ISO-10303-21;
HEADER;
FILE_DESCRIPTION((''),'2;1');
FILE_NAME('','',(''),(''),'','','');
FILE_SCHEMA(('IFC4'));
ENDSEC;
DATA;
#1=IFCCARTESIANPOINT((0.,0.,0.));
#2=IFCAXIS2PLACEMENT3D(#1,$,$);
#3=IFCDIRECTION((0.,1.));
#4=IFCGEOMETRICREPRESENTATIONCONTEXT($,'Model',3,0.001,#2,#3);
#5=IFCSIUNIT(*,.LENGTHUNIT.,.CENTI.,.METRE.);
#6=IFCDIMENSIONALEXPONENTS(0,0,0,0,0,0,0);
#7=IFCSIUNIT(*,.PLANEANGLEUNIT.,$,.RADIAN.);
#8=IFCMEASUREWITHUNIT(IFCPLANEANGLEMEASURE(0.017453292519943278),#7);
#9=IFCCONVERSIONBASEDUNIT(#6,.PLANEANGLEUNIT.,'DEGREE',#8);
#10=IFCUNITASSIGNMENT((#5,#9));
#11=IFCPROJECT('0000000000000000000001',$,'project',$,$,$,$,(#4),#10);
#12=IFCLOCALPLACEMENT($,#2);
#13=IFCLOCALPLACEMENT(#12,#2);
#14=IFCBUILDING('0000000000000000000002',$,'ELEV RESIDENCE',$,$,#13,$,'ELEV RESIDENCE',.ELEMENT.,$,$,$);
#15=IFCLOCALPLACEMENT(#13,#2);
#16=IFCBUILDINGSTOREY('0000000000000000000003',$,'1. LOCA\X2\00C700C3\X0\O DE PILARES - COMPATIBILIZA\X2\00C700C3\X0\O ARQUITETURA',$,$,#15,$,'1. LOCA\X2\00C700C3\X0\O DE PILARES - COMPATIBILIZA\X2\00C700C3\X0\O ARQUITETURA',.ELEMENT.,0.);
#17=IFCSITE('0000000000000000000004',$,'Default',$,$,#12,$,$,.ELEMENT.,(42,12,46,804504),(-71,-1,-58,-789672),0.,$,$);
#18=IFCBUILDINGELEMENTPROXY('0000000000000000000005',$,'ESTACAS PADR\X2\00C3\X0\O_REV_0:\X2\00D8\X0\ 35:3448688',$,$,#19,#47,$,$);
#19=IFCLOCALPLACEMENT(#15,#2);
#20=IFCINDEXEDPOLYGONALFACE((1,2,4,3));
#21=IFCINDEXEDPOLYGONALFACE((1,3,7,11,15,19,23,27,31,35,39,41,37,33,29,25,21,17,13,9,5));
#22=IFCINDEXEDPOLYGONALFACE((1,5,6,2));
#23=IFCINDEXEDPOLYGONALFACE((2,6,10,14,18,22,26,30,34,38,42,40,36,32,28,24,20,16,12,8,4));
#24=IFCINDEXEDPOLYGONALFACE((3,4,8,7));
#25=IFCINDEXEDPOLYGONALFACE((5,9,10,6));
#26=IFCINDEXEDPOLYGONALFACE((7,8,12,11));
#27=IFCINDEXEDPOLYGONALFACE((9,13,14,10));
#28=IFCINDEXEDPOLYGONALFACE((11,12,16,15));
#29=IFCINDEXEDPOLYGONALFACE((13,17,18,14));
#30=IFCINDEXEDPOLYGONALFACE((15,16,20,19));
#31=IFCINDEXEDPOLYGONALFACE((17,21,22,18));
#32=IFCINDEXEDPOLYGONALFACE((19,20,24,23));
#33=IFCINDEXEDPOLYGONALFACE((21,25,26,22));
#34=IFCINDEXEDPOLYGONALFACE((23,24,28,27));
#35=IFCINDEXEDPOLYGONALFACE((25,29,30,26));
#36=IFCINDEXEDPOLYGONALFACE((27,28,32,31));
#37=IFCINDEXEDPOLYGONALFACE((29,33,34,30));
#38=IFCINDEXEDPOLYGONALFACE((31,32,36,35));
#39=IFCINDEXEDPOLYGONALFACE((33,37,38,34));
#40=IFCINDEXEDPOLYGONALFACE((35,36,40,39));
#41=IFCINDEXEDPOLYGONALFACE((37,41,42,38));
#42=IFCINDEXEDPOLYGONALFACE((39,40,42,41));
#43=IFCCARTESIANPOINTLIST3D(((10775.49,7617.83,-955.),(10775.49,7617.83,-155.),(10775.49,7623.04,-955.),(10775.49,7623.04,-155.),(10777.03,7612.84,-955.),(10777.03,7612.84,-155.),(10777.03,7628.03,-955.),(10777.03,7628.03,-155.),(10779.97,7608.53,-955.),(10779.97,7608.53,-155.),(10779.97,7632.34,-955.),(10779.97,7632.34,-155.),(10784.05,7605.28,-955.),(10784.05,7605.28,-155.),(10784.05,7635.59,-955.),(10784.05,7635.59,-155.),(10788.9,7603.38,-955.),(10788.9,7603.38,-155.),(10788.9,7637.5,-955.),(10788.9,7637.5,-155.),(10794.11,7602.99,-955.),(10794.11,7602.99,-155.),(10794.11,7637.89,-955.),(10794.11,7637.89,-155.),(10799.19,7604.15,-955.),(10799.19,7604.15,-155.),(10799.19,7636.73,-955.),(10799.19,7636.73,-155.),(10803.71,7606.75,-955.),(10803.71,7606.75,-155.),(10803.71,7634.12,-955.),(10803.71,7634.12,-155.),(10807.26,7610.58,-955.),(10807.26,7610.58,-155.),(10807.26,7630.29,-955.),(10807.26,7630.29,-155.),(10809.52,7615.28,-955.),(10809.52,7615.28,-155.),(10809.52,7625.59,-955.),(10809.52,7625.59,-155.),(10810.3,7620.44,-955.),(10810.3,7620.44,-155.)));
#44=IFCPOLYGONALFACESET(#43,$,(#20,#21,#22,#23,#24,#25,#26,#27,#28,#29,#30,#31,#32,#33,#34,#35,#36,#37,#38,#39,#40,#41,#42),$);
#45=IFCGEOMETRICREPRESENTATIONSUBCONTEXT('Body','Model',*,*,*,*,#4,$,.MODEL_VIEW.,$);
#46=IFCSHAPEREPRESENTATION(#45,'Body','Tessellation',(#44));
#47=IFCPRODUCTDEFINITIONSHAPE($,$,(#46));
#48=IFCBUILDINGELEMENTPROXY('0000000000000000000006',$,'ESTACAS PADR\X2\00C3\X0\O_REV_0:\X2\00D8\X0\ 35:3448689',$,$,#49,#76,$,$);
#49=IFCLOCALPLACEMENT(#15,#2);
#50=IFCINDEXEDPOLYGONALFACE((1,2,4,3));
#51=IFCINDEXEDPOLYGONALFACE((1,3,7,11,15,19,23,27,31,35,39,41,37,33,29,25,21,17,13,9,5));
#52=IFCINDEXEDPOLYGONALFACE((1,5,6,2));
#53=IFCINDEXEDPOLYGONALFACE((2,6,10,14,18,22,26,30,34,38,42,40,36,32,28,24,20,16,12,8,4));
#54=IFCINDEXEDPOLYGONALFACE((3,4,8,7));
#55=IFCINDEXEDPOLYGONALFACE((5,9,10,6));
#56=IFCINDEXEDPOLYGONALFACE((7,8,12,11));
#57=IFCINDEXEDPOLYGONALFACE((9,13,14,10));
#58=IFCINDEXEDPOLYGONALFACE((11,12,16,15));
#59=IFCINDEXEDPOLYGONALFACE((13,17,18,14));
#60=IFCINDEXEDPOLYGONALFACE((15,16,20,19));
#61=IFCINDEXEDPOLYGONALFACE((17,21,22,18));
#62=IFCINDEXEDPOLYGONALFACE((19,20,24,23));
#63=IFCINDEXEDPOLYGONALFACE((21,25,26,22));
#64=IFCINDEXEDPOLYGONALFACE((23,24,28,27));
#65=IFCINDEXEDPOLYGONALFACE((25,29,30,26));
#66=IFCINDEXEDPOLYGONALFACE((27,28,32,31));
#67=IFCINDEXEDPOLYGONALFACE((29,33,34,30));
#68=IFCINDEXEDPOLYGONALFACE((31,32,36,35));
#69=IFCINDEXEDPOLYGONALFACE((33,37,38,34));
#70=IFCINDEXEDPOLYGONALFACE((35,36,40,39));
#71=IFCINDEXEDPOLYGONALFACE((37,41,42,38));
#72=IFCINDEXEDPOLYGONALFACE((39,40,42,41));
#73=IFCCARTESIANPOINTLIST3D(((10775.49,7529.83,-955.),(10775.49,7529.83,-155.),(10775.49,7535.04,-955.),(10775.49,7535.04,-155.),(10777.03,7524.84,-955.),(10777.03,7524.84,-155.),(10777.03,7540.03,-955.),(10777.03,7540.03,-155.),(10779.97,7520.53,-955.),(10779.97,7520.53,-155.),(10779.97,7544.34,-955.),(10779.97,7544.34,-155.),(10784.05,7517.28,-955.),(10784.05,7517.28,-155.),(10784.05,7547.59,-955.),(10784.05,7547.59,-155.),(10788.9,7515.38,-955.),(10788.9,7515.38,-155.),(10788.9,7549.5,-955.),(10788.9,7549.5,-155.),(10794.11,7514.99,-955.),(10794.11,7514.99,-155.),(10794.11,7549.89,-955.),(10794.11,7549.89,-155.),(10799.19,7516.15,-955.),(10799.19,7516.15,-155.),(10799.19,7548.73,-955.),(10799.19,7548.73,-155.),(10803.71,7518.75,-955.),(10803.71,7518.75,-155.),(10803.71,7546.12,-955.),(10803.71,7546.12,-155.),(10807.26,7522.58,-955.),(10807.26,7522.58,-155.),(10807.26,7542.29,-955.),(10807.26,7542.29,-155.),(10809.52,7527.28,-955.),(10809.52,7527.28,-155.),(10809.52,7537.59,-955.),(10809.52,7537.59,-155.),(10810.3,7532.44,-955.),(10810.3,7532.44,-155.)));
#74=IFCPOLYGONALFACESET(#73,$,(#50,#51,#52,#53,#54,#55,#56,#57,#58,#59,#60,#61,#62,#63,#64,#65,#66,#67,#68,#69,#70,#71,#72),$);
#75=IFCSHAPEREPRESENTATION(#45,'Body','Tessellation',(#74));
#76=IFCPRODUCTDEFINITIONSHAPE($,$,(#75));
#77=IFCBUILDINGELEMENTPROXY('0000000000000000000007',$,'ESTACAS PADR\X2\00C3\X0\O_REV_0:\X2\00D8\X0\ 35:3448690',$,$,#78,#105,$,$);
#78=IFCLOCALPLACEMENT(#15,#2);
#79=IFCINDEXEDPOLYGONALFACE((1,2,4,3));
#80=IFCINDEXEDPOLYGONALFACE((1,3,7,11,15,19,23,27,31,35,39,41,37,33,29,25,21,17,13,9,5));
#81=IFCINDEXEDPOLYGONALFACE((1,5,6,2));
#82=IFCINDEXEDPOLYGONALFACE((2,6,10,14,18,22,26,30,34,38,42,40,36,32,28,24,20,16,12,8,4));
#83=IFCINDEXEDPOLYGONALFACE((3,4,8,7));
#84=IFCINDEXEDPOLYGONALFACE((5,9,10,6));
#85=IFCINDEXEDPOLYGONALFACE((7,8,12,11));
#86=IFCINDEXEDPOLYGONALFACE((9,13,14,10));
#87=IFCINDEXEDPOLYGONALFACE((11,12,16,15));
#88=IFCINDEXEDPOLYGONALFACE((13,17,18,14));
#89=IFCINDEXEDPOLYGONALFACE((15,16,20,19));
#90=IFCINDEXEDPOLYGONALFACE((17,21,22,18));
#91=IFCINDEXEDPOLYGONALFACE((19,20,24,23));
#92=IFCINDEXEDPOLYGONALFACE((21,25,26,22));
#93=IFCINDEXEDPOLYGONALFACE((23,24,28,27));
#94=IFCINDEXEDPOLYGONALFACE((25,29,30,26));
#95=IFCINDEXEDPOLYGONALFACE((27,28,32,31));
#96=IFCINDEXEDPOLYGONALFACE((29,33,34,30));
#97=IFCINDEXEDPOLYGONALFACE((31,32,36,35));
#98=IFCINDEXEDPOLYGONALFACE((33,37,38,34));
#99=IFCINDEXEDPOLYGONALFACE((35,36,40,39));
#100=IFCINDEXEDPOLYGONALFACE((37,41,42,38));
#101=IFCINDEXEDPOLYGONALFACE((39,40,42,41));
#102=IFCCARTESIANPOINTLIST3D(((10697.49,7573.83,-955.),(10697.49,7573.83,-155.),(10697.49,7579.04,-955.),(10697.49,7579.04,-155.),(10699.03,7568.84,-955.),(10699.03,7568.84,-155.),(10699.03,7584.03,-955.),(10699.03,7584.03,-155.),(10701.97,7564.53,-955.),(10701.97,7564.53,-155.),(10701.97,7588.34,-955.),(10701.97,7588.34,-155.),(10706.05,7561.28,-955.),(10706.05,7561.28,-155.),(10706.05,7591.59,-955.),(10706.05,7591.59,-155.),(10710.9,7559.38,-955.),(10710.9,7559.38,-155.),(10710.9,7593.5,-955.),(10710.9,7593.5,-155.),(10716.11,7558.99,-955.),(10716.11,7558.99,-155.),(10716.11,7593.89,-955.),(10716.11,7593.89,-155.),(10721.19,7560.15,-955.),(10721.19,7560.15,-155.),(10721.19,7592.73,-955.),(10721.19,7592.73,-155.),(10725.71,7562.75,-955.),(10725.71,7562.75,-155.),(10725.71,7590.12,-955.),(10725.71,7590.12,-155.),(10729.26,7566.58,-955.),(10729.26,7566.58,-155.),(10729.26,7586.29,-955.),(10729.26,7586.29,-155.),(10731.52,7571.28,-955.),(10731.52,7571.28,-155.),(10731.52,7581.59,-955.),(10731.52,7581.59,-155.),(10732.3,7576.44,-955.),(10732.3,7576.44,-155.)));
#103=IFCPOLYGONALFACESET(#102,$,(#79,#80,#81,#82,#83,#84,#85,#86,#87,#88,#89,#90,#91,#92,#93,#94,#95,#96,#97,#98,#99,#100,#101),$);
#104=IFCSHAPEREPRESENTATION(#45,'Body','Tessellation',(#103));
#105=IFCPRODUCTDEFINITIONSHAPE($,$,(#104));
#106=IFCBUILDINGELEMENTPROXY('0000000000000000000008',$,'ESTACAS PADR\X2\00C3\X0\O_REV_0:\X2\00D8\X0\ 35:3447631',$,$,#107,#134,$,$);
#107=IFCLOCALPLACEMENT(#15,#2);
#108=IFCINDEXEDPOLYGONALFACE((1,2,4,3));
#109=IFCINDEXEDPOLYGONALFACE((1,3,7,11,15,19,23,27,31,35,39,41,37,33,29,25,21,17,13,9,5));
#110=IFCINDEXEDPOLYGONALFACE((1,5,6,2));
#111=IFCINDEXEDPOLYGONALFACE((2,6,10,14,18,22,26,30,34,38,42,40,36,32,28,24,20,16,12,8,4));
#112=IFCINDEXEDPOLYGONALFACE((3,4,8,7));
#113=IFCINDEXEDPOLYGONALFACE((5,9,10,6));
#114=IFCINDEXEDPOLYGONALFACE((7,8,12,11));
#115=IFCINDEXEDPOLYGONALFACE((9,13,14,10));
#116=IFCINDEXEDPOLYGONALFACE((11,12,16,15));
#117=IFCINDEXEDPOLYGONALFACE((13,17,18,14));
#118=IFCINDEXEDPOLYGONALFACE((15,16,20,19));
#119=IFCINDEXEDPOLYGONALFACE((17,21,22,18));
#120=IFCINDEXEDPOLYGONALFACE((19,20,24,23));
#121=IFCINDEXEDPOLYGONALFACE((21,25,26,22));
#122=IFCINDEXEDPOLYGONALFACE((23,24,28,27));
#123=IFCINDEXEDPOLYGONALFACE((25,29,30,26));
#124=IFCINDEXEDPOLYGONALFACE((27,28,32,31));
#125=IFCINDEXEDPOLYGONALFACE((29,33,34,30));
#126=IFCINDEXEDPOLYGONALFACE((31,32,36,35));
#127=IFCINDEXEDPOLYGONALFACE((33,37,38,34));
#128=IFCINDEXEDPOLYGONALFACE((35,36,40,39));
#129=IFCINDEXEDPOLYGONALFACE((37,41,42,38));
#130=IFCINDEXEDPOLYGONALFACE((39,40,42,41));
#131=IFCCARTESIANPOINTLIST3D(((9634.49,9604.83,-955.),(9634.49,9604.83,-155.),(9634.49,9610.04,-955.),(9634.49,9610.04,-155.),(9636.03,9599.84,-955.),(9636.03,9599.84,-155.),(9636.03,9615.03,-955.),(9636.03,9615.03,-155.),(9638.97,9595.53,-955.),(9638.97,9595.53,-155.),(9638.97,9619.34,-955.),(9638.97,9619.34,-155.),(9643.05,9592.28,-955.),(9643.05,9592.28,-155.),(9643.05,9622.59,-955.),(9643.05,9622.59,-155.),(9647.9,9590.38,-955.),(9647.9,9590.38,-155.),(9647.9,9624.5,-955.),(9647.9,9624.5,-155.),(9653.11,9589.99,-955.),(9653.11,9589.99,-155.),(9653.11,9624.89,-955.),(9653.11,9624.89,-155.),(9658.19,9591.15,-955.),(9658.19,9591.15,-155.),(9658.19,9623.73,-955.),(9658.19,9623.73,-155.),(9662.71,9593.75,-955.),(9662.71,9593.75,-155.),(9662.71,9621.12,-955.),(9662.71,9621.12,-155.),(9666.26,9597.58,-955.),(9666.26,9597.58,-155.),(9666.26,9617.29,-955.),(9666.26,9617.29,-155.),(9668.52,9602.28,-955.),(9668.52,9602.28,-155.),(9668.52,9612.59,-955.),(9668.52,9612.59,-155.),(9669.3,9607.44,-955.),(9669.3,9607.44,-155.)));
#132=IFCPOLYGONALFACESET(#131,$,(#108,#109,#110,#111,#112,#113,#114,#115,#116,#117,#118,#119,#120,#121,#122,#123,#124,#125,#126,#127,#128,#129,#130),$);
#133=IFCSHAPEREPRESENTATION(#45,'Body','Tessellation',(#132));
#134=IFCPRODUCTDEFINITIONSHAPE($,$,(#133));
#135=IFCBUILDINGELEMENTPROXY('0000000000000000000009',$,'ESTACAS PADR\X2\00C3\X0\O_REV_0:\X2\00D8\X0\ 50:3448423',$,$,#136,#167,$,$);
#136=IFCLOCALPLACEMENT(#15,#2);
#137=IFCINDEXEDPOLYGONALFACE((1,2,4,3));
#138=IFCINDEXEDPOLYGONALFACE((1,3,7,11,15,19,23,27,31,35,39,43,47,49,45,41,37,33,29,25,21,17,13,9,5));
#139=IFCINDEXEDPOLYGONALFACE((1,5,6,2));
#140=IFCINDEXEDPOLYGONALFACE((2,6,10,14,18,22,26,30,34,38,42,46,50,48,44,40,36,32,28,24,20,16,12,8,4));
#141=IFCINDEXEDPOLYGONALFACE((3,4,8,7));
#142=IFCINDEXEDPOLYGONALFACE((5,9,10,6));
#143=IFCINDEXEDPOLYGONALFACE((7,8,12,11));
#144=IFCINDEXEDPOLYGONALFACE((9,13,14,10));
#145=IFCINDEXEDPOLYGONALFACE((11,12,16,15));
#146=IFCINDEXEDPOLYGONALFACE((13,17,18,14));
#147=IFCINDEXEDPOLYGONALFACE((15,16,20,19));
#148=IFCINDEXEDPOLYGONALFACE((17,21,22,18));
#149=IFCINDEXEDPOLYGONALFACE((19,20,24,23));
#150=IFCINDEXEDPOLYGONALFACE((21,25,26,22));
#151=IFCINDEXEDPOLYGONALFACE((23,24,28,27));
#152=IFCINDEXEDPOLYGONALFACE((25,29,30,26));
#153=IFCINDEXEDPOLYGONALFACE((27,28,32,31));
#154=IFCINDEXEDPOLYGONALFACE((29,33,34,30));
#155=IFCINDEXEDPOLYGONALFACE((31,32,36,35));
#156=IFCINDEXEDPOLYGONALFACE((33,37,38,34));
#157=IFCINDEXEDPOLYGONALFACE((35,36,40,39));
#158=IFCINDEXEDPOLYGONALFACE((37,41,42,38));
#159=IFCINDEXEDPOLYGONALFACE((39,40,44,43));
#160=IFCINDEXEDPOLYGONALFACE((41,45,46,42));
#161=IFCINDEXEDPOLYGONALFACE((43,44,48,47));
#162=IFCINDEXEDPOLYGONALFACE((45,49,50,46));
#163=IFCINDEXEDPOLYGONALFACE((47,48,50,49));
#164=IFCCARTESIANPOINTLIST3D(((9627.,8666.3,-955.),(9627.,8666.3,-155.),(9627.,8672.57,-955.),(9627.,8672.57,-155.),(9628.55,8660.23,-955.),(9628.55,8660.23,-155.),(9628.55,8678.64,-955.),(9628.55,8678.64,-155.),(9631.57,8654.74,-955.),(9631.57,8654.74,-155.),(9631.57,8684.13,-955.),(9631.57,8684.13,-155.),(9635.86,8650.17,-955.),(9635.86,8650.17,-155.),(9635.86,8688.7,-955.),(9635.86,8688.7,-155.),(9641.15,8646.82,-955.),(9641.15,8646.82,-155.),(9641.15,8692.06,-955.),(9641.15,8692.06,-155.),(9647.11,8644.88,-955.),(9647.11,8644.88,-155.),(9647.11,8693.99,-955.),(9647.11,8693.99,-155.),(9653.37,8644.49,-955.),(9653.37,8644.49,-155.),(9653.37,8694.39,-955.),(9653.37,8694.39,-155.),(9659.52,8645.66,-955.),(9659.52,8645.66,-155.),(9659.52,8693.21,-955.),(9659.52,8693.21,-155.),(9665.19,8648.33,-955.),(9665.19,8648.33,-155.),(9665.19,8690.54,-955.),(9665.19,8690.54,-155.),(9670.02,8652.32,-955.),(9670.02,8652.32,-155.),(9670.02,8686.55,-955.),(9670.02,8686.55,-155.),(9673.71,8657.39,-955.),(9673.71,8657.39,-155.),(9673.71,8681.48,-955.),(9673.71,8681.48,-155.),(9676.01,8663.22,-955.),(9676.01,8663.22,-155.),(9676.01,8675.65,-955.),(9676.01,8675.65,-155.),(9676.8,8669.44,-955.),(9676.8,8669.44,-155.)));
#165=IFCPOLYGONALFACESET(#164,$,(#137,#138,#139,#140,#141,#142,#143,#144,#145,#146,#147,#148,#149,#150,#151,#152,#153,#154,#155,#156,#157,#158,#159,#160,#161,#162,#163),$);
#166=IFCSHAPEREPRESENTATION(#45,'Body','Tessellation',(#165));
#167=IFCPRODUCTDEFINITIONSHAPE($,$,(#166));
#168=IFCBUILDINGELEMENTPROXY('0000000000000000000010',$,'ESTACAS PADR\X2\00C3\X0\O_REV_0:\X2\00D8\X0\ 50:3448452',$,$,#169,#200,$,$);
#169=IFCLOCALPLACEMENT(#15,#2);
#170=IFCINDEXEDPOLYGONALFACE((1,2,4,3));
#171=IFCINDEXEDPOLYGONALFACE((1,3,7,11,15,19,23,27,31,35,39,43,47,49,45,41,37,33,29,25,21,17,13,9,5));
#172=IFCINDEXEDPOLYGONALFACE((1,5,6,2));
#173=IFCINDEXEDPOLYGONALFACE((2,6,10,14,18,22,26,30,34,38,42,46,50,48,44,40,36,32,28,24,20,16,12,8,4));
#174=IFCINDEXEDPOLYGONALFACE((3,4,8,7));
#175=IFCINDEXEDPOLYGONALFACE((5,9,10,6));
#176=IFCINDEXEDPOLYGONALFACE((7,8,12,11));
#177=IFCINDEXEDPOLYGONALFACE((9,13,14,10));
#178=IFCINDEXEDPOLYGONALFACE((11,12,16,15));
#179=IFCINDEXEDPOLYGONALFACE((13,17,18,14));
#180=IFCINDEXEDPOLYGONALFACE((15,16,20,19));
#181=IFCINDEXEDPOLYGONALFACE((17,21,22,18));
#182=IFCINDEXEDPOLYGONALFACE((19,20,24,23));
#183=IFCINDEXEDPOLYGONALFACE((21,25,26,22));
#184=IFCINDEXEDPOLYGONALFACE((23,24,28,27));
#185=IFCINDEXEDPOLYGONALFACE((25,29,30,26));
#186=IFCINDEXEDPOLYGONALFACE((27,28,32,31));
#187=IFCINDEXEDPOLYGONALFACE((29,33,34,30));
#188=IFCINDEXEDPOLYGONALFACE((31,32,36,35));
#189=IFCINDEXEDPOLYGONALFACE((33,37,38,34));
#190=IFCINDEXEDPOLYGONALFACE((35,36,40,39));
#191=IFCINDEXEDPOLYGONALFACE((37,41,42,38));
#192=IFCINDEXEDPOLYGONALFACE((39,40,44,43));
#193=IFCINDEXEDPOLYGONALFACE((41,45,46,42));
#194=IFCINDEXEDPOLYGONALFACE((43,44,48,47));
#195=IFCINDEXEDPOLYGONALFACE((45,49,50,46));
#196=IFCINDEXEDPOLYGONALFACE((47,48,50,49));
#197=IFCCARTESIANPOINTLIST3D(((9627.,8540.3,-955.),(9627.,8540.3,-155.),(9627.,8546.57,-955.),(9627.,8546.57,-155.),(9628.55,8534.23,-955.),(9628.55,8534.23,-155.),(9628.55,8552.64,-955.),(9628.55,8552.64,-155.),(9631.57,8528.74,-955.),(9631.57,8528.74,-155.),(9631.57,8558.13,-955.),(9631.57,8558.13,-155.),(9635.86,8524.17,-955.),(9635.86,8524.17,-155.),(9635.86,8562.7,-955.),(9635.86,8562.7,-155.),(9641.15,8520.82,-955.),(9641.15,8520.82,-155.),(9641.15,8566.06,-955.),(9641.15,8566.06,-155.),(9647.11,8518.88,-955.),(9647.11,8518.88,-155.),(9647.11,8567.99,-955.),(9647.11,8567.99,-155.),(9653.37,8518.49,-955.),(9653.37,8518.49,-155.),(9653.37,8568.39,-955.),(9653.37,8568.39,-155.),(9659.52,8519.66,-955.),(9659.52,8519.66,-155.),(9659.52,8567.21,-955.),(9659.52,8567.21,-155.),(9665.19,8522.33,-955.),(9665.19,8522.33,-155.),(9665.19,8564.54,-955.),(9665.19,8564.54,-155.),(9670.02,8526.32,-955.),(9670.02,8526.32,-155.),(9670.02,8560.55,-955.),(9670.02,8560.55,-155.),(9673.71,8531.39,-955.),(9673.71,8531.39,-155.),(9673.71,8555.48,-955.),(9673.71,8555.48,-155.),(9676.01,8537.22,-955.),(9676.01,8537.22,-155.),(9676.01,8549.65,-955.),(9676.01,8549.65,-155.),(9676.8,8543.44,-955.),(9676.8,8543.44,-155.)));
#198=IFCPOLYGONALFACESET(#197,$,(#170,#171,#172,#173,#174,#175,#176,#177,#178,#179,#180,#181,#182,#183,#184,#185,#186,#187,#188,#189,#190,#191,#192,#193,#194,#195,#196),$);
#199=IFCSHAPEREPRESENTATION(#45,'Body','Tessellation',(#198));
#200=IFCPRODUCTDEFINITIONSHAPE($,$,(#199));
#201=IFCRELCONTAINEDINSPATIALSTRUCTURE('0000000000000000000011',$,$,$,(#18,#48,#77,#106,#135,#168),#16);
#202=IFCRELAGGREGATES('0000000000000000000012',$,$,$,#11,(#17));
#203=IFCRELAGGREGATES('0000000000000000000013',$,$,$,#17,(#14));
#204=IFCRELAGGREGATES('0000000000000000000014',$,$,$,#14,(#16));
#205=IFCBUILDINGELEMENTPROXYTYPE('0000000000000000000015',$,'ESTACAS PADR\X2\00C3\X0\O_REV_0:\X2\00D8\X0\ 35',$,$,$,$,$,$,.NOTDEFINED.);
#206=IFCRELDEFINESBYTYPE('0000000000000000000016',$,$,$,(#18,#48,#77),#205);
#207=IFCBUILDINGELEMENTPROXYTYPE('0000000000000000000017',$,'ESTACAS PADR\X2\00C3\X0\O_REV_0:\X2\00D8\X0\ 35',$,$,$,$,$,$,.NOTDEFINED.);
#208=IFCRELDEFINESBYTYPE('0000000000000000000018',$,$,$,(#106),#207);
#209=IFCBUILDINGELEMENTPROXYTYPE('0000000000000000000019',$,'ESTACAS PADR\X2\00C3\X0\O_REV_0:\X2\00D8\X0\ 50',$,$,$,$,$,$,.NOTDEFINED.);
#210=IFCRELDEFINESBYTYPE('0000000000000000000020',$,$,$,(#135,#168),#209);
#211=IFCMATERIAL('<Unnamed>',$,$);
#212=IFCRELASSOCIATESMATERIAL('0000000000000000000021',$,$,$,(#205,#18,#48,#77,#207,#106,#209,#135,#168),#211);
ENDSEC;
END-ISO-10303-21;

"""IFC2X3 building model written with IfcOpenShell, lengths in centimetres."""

from ifc_helpers import new_model, entity, si_unit, converted_unit, direction, frame, frame_2d, origin, place, context, subcontext, project, spatial, circle, extrude, source, transform, mapped, material, type_object, type_shapes, element, save


model = new_model("IFC2X3")

# Units and contexts
model_context = context("Model", 3, precision=0.001, world=origin(), true_north=direction((0.0, 1.0)))
body_context = subcontext(model_context, "Body", "Model", "MODEL_VIEW")
ifc_project = project(units=[si_unit("LENGTHUNIT", "METRE", prefix="CENTI"), converted_unit("PLANEANGLEUNIT", "DEGREE", entity("IfcPlaneAngleMeasure", 0.017453292519943278), si_unit("PLANEANGLEUNIT", "RADIAN"), dimensions=[0, 0, 0, 0, 0, 0, 0])], contexts=[model_context])

# Site, building, storey
site_placement = place(None, origin())
site = spatial("IfcSite", under=ifc_project, at=site_placement, Name="Default", CompositionType="ELEMENT", RefLatitude=(42, 12, 46, 804504), RefLongitude=(-71, -1, -58, -789672), RefElevation=0.0)
building_placement = place(site_placement, origin())
building = spatial("IfcBuilding", under=site, at=building_placement, Name="ELEV RESIDENCE", LongName="ELEV RESIDENCE", CompositionType="ELEMENT")
storey_placement = place(building_placement, origin())
storey = spatial("IfcBuildingStorey", under=building, at=storey_placement, Name="1. LOCAÇÃO DE PILARES - COMPATIBILIZAÇÃO ARQUITETURA", LongName="1. LOCAÇÃO DE PILARES - COMPATIBILIZAÇÃO ARQUITETURA", CompositionType="ELEMENT", Elevation=0.0)

# Building element proxies
ifc_material_1 = material(Name="<Unnamed>")
building_element_proxy_type_1 = type_object("IfcBuildingElementProxyType", Name="ESTACAS PADRÃO_REV_0:Ø 35", PredefinedType="NOTDEFINED", material=ifc_material_1)
shared_shape_1 = source(origin(), body_context, "Body", "SweptSolid", [
    extrude(circle(Radius=17.5, at=frame_2d((0.0, 0.0), x_axis=(1.0, 0.0))), frame((0.0, 0.0, -955.0)), (0.0, 0.0, 1.0), 800.0),
])
type_shapes(building_element_proxy_type_1, [shared_shape_1])
for number, where, name in (
    (1, (10792.8, 7620.44, 0.0), "ESTACAS PADRÃO_REV_0:Ø 35:3448688"),
    (2, (10792.8, 7532.44, 0.0), "ESTACAS PADRÃO_REV_0:Ø 35:3448689"),
    (3, (10714.8, 7576.44, 0.0), "ESTACAS PADRÃO_REV_0:Ø 35:3448690"),
):
    element("IfcBuildingElementProxy", number, at=place(storey_placement, frame(where)), inside=storey, type_object=building_element_proxy_type_1, material=ifc_material_1, Name=name, context=body_context, shape_type="MappedRepresentation", body=[
        mapped(shared_shape_1, transform((0.0, 0.0, 0.0), scale=1.0)),
    ])
building_element_proxy_type_2 = type_object("IfcBuildingElementProxyType", Name="ESTACAS PADRÃO_REV_0:Ø 35", PredefinedType="NOTDEFINED", material=ifc_material_1)
shared_shape_2 = source(origin(), body_context, "Body", "SweptSolid", [
    extrude(circle(Radius=17.5, at=frame_2d((0.0, 0.0), x_axis=(1.0, 0.0))), frame((0.0, 0.0, -955.0)), (0.0, 0.0, 1.0), 800.0),
])
type_shapes(building_element_proxy_type_2, [shared_shape_2])
proxy_placement = place(storey_placement, frame((9651.8, 9607.44, 0.0)))
element("IfcBuildingElementProxy", 4, at=proxy_placement, inside=storey, type_object=building_element_proxy_type_2, material=ifc_material_1, Name="ESTACAS PADRÃO_REV_0:Ø 35:3447631", context=body_context, shape_type="MappedRepresentation", body=[
    mapped(shared_shape_2, transform((0.0, 0.0, 0.0), scale=1.0)),
])
building_element_proxy_type_3 = type_object("IfcBuildingElementProxyType", Name="ESTACAS PADRÃO_REV_0:Ø 50", PredefinedType="NOTDEFINED", material=ifc_material_1)
shared_shape_3 = source(origin(), body_context, "Body", "SweptSolid", [
    extrude(circle(Radius=25.0, at=frame_2d((0.0, 0.0), x_axis=(1.0, 0.0))), frame((0.0, 0.0, -955.0)), (0.0, 0.0, 1.0), 800.0),
])
type_shapes(building_element_proxy_type_3, [shared_shape_3])
for number, where, name in (
    (5, (9651.8, 8669.44, 0.0), "ESTACAS PADRÃO_REV_0:Ø 50:3448423"),
    (6, (9651.8, 8543.44, 0.0), "ESTACAS PADRÃO_REV_0:Ø 50:3448452"),
):
    element("IfcBuildingElementProxy", number, at=place(storey_placement, frame(where)), inside=storey, type_object=building_element_proxy_type_3, material=ifc_material_1, Name=name, context=body_context, shape_type="MappedRepresentation", body=[
        mapped(shared_shape_3, transform((0.0, 0.0, 0.0), scale=1.0)),
    ])

save(model, "model.ifc")
